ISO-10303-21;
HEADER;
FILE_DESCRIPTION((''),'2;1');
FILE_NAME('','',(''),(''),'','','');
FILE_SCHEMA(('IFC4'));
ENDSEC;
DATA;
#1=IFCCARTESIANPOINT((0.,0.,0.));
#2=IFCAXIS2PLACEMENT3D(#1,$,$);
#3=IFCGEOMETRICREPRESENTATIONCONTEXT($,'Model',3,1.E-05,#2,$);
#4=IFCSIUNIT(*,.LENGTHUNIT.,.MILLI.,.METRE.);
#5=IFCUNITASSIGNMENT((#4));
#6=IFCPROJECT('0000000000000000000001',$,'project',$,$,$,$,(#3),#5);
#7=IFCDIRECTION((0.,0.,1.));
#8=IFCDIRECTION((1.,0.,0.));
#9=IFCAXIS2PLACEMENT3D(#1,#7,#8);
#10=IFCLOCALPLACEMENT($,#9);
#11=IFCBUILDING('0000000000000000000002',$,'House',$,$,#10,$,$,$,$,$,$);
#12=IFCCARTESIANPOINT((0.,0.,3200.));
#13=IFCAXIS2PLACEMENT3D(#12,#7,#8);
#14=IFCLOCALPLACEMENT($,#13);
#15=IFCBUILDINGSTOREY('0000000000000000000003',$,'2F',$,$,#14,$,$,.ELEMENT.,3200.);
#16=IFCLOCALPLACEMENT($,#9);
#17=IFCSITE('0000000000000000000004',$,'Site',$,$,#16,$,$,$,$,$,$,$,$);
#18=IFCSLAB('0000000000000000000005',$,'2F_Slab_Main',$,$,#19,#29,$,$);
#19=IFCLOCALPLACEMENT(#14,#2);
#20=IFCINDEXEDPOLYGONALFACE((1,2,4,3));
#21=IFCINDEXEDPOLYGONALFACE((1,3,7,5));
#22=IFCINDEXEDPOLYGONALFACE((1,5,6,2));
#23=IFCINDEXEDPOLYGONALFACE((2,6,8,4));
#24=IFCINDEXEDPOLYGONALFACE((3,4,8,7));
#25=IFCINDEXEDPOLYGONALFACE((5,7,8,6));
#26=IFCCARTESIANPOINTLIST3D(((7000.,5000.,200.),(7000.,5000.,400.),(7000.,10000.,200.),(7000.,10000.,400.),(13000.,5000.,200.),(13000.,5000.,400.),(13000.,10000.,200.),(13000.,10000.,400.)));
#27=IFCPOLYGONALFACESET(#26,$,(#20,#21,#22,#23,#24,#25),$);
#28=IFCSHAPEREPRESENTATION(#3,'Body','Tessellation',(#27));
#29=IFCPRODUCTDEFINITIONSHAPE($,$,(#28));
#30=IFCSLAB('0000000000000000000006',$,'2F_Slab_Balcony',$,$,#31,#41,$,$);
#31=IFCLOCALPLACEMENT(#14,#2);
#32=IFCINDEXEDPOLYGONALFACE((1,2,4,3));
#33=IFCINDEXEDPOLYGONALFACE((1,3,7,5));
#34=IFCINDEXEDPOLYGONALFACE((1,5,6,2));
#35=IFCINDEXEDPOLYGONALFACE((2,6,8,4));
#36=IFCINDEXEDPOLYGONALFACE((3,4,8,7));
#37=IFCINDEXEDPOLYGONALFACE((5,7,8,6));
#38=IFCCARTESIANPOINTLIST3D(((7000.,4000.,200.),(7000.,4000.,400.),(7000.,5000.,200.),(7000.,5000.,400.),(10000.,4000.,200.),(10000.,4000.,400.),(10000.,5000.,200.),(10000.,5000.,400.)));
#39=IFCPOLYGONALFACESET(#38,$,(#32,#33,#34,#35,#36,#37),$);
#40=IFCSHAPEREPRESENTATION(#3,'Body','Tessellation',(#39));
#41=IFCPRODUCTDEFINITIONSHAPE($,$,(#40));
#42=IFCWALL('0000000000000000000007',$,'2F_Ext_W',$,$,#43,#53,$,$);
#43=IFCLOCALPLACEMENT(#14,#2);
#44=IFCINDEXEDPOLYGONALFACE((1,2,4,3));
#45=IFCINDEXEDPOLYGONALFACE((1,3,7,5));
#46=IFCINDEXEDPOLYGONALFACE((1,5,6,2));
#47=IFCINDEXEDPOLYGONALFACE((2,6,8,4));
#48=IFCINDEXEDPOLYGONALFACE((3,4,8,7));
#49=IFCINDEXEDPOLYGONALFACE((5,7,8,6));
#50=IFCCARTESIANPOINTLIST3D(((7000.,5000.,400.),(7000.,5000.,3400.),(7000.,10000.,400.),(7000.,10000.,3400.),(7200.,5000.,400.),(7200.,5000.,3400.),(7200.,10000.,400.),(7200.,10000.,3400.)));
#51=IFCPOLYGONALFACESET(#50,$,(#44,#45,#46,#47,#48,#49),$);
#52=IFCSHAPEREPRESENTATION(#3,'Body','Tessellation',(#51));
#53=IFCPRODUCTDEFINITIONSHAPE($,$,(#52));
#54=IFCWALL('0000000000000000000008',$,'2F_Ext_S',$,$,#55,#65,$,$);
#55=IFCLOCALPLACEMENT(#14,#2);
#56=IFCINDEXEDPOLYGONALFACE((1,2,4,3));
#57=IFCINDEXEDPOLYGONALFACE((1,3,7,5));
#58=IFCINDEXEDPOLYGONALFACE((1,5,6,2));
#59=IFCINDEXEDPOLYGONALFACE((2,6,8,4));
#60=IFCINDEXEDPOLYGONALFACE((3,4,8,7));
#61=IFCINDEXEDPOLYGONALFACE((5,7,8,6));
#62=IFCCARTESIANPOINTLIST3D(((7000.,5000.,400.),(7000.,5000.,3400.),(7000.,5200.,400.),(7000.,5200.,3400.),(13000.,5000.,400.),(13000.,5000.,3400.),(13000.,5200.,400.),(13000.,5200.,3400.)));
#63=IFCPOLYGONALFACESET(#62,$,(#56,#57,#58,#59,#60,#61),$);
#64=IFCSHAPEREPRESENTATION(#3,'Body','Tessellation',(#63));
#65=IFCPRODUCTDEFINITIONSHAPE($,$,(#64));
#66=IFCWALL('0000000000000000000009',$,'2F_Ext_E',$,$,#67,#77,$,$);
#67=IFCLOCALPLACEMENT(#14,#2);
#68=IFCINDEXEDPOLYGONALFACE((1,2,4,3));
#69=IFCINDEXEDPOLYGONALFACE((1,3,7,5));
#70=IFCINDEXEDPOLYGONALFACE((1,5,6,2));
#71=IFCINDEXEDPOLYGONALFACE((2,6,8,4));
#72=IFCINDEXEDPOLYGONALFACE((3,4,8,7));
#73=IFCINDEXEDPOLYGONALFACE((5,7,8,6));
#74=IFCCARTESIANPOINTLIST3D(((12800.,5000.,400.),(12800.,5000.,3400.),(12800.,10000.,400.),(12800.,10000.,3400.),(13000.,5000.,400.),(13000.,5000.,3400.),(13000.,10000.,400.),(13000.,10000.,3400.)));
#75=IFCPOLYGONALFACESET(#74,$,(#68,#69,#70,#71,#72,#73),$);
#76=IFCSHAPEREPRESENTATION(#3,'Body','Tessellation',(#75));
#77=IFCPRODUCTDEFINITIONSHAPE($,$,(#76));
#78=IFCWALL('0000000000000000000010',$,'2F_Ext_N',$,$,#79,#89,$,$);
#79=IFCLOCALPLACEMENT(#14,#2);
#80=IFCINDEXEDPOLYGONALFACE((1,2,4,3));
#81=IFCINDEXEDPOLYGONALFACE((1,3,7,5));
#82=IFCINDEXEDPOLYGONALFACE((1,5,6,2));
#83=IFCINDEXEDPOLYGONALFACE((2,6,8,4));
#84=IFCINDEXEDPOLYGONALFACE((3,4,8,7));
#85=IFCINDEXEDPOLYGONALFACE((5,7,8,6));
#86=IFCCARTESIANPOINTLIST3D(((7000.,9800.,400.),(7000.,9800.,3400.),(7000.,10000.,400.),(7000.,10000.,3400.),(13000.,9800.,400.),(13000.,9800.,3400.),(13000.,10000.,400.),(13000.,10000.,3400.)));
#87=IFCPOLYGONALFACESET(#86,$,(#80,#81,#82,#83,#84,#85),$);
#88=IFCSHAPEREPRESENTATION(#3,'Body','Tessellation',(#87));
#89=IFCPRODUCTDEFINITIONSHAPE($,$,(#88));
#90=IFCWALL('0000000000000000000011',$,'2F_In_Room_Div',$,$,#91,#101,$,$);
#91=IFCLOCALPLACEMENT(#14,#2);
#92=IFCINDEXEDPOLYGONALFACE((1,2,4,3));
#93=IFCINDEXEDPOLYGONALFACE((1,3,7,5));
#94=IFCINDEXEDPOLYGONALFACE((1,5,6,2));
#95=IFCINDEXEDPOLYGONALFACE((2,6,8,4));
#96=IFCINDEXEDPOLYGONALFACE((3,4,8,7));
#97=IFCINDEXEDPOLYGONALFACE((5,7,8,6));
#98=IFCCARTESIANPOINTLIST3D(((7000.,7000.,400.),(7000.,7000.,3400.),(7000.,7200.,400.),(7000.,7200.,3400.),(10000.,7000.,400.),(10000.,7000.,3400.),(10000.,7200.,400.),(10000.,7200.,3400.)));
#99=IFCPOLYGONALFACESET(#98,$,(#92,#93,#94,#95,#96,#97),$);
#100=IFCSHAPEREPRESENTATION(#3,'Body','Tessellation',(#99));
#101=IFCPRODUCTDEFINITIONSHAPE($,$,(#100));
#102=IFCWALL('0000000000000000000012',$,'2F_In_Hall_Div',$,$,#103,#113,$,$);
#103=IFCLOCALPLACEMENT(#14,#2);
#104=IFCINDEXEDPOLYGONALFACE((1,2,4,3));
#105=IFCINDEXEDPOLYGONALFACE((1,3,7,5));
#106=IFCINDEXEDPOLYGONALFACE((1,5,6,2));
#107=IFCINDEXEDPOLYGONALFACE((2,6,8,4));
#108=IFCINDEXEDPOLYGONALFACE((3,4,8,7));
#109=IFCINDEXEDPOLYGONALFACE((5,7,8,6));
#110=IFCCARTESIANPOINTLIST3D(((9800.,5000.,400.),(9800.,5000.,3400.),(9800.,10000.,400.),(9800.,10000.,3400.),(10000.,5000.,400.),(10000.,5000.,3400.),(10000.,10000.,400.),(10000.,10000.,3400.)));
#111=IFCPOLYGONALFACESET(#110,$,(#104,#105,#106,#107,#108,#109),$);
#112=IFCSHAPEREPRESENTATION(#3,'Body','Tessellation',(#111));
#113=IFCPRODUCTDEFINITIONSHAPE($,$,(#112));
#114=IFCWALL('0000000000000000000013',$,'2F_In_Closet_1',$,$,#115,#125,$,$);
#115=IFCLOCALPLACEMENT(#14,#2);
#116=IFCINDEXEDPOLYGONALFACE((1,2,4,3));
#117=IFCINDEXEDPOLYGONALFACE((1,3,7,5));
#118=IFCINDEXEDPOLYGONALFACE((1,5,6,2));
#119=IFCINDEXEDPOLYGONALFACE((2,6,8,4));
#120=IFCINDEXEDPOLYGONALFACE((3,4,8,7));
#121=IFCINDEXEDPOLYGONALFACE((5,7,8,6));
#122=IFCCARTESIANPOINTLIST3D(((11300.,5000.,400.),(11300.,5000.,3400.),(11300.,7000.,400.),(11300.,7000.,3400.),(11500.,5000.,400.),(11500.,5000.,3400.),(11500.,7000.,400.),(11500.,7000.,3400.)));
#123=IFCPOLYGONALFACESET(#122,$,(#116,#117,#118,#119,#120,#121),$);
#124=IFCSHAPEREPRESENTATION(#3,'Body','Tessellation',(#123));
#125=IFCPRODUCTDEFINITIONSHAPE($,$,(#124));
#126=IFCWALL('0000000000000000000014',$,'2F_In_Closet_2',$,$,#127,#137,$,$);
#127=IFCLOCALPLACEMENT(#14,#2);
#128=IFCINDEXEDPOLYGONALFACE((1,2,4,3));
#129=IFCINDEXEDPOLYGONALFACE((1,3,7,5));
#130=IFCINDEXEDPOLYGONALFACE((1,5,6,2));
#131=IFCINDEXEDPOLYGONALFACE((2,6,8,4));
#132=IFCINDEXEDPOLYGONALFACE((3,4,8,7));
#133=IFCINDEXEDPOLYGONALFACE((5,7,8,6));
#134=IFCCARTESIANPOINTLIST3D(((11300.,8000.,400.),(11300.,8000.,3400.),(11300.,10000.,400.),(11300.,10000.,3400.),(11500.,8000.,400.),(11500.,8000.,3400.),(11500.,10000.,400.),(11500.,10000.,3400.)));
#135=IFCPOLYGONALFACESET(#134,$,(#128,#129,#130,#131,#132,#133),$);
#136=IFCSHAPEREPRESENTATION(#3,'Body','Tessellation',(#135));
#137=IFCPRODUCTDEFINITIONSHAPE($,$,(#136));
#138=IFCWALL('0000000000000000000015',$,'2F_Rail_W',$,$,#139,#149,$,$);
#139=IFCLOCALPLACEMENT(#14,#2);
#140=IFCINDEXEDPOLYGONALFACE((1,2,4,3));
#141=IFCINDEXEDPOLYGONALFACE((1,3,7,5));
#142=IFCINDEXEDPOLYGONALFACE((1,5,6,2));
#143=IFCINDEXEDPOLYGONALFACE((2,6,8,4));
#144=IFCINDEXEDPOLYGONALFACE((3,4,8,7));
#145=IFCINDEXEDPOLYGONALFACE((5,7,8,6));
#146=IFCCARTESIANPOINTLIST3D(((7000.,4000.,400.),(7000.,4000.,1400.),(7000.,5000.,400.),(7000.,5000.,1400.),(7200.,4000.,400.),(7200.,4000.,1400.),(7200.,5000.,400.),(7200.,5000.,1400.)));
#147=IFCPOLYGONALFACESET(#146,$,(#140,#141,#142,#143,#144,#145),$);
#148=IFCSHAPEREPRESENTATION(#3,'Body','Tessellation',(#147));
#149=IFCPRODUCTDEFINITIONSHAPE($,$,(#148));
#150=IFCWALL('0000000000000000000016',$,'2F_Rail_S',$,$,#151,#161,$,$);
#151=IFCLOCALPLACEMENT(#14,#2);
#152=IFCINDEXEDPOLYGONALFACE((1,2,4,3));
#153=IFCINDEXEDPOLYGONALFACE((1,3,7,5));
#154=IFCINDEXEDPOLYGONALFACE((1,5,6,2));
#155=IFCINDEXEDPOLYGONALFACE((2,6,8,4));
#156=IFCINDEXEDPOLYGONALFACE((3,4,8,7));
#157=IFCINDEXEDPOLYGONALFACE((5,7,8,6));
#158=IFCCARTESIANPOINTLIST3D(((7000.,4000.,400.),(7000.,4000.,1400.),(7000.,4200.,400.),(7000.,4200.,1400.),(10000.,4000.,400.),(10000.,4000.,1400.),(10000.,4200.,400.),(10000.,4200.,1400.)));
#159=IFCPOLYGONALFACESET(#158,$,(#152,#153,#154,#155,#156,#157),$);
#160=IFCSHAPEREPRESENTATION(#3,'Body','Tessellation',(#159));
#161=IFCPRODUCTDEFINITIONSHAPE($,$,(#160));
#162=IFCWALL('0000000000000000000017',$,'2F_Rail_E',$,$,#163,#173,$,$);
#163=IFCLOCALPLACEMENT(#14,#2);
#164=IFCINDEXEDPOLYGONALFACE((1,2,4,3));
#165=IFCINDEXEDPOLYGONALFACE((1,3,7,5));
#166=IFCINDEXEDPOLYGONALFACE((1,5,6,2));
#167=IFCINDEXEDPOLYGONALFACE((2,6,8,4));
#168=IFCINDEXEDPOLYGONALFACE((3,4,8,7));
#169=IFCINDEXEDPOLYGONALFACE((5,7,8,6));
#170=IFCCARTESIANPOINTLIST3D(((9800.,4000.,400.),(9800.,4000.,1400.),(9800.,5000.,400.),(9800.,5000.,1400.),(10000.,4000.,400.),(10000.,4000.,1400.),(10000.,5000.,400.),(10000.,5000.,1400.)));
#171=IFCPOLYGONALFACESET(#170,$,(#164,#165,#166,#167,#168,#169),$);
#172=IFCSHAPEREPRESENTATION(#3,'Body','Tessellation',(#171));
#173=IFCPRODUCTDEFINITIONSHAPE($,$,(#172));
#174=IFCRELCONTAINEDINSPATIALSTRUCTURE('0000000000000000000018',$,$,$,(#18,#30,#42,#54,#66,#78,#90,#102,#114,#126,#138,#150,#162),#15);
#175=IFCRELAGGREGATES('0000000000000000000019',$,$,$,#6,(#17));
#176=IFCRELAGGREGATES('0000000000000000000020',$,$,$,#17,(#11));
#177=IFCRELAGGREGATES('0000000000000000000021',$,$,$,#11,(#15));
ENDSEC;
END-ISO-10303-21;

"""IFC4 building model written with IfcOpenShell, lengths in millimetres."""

from ifc_helpers import new_model, si_unit, frame, origin, origin_with_axes, place, context, project, spatial, rectangle, extrude, element, save


model = new_model("IFC4")

# Units and contexts
model_context = context("Model", 3, precision=1e-05, world=origin())
ifc_project = project(units=[si_unit("LENGTHUNIT", "METRE", prefix="MILLI")], contexts=[model_context])

# Site, building, storey
site_placement = place(None, origin_with_axes())
site = spatial("IfcSite", under=ifc_project, at=site_placement, Name="Site")
building_placement = place(None, origin_with_axes())
building = spatial("IfcBuilding", under=site, at=building_placement, Name="House")
storey_placement = place(None, frame((0.0, 0.0, 3200.0), z_axis=(0.0, 0.0, 1.0), x_axis=(1.0, 0.0, 0.0)))
storey = spatial("IfcBuildingStorey", under=building, at=storey_placement, Name="2F", CompositionType="ELEMENT", Elevation=3200.0)

# Slabs
slab_1_placement = place(None, frame((7000.0, 5000.0, 3400.0), z_axis=(0.0, 0.0, 1.0), x_axis=(1.0, 0.0, 0.0)))
element("IfcSlab", 1, at=slab_1_placement, inside=storey, Name="2F_Slab_Main", context=model_context, shape_type="SweptSolid", body=[
    extrude(rectangle(XDim=6000.0, YDim=5000.0), frame((3000.0, 2500.0, 0.0)), (0.0, 0.0, 1.0), 200.0),
])
slab_2_placement = place(None, frame((7000.0, 4000.0, 3400.0), z_axis=(0.0, 0.0, 1.0), x_axis=(1.0, 0.0, 0.0)))
element("IfcSlab", 2, at=slab_2_placement, inside=storey, Name="2F_Slab_Balcony", context=model_context, shape_type="SweptSolid", body=[
    extrude(rectangle(XDim=3000.0, YDim=1000.0), frame((1500.0, 500.0, 0.0)), (0.0, 0.0, 1.0), 200.0),
])

# Walls
wall_1_placement = place(None, frame((7000.0, 5000.0, 3600.0), z_axis=(0.0, 0.0, 1.0), x_axis=(1.0, 0.0, 0.0)))
element("IfcWall", 3, at=wall_1_placement, inside=storey, Name="2F_Ext_W", context=model_context, shape_type="SweptSolid", body=[
    extrude(rectangle(XDim=200.0, YDim=5000.0), frame((100.0, 2500.0, 0.0)), (0.0, 0.0, 1.0), 3000.0),
])
wall_2_placement = place(None, frame((7000.0, 5000.0, 3600.0), z_axis=(0.0, 0.0, 1.0), x_axis=(1.0, 0.0, 0.0)))
element("IfcWall", 4, at=wall_2_placement, inside=storey, Name="2F_Ext_S", context=model_context, shape_type="SweptSolid", body=[
    extrude(rectangle(XDim=6000.0, YDim=200.0), frame((3000.0, 100.0, 0.0)), (0.0, 0.0, 1.0), 3000.0),
])
wall_3_placement = place(None, frame((12800.0, 5000.0, 3600.0), z_axis=(0.0, 0.0, 1.0), x_axis=(1.0, 0.0, 0.0)))
element("IfcWall", 5, at=wall_3_placement, inside=storey, Name="2F_Ext_E", context=model_context, shape_type="SweptSolid", body=[
    extrude(rectangle(XDim=200.0, YDim=5000.0), frame((100.0, 2500.0, 0.0)), (0.0, 0.0, 1.0), 3000.0),
])
wall_4_placement = place(None, frame((7000.0, 9800.0, 3600.0), z_axis=(0.0, 0.0, 1.0), x_axis=(1.0, 0.0, 0.0)))
element("IfcWall", 6, at=wall_4_placement, inside=storey, Name="2F_Ext_N", context=model_context, shape_type="SweptSolid", body=[
    extrude(rectangle(XDim=6000.0, YDim=200.0), frame((3000.0, 100.0, 0.0)), (0.0, 0.0, 1.0), 3000.0),
])
wall_5_placement = place(None, frame((7000.0, 7000.0, 3600.0), z_axis=(0.0, 0.0, 1.0), x_axis=(1.0, 0.0, 0.0)))
element("IfcWall", 7, at=wall_5_placement, inside=storey, Name="2F_In_Room_Div", context=model_context, shape_type="SweptSolid", body=[
    extrude(rectangle(XDim=3000.0, YDim=200.0), frame((1500.0, 100.0, 0.0)), (0.0, 0.0, 1.0), 3000.0),
])
wall_6_placement = place(None, frame((9800.0, 5000.0, 3600.0), z_axis=(0.0, 0.0, 1.0), x_axis=(1.0, 0.0, 0.0)))
element("IfcWall", 8, at=wall_6_placement, inside=storey, Name="2F_In_Hall_Div", context=model_context, shape_type="SweptSolid", body=[
    extrude(rectangle(XDim=200.0, YDim=5000.0), frame((100.0, 2500.0, 0.0)), (0.0, 0.0, 1.0), 3000.0),
])
for number, where, z_axis, x_axis, name in (
    (9, (11300.0, 5000.0, 3600.0), (0.0, 0.0, 1.0), (1.0, 0.0, 0.0), "2F_In_Closet_1"),
    (10, (11300.0, 8000.0, 3600.0), (0.0, 0.0, 1.0), (1.0, 0.0, 0.0), "2F_In_Closet_2"),
):
    element("IfcWall", number, at=place(None, frame(where, z_axis=z_axis, x_axis=x_axis)), inside=storey, Name=name, context=model_context, shape_type="SweptSolid", body=[
        extrude(rectangle(XDim=200.0, YDim=2000.0), frame((100.0, 1000.0, 0.0)), (0.0, 0.0, 1.0), 3000.0),
    ])
wall_7_placement = place(None, frame((7000.0, 4000.0, 3600.0), z_axis=(0.0, 0.0, 1.0), x_axis=(1.0, 0.0, 0.0)))
element("IfcWall", 11, at=wall_7_placement, inside=storey, Name="2F_Rail_W", context=model_context, shape_type="SweptSolid", body=[
    extrude(rectangle(XDim=200.0, YDim=1000.0), frame((100.0, 500.0, 0.0)), (0.0, 0.0, 1.0), 1000.0),
])
wall_8_placement = place(None, frame((7000.0, 4000.0, 3600.0), z_axis=(0.0, 0.0, 1.0), x_axis=(1.0, 0.0, 0.0)))
element("IfcWall", 12, at=wall_8_placement, inside=storey, Name="2F_Rail_S", context=model_context, shape_type="SweptSolid", body=[
    extrude(rectangle(XDim=3000.0, YDim=200.0), frame((1500.0, 100.0, 0.0)), (0.0, 0.0, 1.0), 1000.0),
])
wall_9_placement = place(None, frame((9800.0, 4000.0, 3600.0), z_axis=(0.0, 0.0, 1.0), x_axis=(1.0, 0.0, 0.0)))
element("IfcWall", 13, at=wall_9_placement, inside=storey, Name="2F_Rail_E", context=model_context, shape_type="SweptSolid", body=[
    extrude(rectangle(XDim=200.0, YDim=1000.0), frame((100.0, 500.0, 0.0)), (0.0, 0.0, 1.0), 1000.0),
])

save(model, "model.ifc")
